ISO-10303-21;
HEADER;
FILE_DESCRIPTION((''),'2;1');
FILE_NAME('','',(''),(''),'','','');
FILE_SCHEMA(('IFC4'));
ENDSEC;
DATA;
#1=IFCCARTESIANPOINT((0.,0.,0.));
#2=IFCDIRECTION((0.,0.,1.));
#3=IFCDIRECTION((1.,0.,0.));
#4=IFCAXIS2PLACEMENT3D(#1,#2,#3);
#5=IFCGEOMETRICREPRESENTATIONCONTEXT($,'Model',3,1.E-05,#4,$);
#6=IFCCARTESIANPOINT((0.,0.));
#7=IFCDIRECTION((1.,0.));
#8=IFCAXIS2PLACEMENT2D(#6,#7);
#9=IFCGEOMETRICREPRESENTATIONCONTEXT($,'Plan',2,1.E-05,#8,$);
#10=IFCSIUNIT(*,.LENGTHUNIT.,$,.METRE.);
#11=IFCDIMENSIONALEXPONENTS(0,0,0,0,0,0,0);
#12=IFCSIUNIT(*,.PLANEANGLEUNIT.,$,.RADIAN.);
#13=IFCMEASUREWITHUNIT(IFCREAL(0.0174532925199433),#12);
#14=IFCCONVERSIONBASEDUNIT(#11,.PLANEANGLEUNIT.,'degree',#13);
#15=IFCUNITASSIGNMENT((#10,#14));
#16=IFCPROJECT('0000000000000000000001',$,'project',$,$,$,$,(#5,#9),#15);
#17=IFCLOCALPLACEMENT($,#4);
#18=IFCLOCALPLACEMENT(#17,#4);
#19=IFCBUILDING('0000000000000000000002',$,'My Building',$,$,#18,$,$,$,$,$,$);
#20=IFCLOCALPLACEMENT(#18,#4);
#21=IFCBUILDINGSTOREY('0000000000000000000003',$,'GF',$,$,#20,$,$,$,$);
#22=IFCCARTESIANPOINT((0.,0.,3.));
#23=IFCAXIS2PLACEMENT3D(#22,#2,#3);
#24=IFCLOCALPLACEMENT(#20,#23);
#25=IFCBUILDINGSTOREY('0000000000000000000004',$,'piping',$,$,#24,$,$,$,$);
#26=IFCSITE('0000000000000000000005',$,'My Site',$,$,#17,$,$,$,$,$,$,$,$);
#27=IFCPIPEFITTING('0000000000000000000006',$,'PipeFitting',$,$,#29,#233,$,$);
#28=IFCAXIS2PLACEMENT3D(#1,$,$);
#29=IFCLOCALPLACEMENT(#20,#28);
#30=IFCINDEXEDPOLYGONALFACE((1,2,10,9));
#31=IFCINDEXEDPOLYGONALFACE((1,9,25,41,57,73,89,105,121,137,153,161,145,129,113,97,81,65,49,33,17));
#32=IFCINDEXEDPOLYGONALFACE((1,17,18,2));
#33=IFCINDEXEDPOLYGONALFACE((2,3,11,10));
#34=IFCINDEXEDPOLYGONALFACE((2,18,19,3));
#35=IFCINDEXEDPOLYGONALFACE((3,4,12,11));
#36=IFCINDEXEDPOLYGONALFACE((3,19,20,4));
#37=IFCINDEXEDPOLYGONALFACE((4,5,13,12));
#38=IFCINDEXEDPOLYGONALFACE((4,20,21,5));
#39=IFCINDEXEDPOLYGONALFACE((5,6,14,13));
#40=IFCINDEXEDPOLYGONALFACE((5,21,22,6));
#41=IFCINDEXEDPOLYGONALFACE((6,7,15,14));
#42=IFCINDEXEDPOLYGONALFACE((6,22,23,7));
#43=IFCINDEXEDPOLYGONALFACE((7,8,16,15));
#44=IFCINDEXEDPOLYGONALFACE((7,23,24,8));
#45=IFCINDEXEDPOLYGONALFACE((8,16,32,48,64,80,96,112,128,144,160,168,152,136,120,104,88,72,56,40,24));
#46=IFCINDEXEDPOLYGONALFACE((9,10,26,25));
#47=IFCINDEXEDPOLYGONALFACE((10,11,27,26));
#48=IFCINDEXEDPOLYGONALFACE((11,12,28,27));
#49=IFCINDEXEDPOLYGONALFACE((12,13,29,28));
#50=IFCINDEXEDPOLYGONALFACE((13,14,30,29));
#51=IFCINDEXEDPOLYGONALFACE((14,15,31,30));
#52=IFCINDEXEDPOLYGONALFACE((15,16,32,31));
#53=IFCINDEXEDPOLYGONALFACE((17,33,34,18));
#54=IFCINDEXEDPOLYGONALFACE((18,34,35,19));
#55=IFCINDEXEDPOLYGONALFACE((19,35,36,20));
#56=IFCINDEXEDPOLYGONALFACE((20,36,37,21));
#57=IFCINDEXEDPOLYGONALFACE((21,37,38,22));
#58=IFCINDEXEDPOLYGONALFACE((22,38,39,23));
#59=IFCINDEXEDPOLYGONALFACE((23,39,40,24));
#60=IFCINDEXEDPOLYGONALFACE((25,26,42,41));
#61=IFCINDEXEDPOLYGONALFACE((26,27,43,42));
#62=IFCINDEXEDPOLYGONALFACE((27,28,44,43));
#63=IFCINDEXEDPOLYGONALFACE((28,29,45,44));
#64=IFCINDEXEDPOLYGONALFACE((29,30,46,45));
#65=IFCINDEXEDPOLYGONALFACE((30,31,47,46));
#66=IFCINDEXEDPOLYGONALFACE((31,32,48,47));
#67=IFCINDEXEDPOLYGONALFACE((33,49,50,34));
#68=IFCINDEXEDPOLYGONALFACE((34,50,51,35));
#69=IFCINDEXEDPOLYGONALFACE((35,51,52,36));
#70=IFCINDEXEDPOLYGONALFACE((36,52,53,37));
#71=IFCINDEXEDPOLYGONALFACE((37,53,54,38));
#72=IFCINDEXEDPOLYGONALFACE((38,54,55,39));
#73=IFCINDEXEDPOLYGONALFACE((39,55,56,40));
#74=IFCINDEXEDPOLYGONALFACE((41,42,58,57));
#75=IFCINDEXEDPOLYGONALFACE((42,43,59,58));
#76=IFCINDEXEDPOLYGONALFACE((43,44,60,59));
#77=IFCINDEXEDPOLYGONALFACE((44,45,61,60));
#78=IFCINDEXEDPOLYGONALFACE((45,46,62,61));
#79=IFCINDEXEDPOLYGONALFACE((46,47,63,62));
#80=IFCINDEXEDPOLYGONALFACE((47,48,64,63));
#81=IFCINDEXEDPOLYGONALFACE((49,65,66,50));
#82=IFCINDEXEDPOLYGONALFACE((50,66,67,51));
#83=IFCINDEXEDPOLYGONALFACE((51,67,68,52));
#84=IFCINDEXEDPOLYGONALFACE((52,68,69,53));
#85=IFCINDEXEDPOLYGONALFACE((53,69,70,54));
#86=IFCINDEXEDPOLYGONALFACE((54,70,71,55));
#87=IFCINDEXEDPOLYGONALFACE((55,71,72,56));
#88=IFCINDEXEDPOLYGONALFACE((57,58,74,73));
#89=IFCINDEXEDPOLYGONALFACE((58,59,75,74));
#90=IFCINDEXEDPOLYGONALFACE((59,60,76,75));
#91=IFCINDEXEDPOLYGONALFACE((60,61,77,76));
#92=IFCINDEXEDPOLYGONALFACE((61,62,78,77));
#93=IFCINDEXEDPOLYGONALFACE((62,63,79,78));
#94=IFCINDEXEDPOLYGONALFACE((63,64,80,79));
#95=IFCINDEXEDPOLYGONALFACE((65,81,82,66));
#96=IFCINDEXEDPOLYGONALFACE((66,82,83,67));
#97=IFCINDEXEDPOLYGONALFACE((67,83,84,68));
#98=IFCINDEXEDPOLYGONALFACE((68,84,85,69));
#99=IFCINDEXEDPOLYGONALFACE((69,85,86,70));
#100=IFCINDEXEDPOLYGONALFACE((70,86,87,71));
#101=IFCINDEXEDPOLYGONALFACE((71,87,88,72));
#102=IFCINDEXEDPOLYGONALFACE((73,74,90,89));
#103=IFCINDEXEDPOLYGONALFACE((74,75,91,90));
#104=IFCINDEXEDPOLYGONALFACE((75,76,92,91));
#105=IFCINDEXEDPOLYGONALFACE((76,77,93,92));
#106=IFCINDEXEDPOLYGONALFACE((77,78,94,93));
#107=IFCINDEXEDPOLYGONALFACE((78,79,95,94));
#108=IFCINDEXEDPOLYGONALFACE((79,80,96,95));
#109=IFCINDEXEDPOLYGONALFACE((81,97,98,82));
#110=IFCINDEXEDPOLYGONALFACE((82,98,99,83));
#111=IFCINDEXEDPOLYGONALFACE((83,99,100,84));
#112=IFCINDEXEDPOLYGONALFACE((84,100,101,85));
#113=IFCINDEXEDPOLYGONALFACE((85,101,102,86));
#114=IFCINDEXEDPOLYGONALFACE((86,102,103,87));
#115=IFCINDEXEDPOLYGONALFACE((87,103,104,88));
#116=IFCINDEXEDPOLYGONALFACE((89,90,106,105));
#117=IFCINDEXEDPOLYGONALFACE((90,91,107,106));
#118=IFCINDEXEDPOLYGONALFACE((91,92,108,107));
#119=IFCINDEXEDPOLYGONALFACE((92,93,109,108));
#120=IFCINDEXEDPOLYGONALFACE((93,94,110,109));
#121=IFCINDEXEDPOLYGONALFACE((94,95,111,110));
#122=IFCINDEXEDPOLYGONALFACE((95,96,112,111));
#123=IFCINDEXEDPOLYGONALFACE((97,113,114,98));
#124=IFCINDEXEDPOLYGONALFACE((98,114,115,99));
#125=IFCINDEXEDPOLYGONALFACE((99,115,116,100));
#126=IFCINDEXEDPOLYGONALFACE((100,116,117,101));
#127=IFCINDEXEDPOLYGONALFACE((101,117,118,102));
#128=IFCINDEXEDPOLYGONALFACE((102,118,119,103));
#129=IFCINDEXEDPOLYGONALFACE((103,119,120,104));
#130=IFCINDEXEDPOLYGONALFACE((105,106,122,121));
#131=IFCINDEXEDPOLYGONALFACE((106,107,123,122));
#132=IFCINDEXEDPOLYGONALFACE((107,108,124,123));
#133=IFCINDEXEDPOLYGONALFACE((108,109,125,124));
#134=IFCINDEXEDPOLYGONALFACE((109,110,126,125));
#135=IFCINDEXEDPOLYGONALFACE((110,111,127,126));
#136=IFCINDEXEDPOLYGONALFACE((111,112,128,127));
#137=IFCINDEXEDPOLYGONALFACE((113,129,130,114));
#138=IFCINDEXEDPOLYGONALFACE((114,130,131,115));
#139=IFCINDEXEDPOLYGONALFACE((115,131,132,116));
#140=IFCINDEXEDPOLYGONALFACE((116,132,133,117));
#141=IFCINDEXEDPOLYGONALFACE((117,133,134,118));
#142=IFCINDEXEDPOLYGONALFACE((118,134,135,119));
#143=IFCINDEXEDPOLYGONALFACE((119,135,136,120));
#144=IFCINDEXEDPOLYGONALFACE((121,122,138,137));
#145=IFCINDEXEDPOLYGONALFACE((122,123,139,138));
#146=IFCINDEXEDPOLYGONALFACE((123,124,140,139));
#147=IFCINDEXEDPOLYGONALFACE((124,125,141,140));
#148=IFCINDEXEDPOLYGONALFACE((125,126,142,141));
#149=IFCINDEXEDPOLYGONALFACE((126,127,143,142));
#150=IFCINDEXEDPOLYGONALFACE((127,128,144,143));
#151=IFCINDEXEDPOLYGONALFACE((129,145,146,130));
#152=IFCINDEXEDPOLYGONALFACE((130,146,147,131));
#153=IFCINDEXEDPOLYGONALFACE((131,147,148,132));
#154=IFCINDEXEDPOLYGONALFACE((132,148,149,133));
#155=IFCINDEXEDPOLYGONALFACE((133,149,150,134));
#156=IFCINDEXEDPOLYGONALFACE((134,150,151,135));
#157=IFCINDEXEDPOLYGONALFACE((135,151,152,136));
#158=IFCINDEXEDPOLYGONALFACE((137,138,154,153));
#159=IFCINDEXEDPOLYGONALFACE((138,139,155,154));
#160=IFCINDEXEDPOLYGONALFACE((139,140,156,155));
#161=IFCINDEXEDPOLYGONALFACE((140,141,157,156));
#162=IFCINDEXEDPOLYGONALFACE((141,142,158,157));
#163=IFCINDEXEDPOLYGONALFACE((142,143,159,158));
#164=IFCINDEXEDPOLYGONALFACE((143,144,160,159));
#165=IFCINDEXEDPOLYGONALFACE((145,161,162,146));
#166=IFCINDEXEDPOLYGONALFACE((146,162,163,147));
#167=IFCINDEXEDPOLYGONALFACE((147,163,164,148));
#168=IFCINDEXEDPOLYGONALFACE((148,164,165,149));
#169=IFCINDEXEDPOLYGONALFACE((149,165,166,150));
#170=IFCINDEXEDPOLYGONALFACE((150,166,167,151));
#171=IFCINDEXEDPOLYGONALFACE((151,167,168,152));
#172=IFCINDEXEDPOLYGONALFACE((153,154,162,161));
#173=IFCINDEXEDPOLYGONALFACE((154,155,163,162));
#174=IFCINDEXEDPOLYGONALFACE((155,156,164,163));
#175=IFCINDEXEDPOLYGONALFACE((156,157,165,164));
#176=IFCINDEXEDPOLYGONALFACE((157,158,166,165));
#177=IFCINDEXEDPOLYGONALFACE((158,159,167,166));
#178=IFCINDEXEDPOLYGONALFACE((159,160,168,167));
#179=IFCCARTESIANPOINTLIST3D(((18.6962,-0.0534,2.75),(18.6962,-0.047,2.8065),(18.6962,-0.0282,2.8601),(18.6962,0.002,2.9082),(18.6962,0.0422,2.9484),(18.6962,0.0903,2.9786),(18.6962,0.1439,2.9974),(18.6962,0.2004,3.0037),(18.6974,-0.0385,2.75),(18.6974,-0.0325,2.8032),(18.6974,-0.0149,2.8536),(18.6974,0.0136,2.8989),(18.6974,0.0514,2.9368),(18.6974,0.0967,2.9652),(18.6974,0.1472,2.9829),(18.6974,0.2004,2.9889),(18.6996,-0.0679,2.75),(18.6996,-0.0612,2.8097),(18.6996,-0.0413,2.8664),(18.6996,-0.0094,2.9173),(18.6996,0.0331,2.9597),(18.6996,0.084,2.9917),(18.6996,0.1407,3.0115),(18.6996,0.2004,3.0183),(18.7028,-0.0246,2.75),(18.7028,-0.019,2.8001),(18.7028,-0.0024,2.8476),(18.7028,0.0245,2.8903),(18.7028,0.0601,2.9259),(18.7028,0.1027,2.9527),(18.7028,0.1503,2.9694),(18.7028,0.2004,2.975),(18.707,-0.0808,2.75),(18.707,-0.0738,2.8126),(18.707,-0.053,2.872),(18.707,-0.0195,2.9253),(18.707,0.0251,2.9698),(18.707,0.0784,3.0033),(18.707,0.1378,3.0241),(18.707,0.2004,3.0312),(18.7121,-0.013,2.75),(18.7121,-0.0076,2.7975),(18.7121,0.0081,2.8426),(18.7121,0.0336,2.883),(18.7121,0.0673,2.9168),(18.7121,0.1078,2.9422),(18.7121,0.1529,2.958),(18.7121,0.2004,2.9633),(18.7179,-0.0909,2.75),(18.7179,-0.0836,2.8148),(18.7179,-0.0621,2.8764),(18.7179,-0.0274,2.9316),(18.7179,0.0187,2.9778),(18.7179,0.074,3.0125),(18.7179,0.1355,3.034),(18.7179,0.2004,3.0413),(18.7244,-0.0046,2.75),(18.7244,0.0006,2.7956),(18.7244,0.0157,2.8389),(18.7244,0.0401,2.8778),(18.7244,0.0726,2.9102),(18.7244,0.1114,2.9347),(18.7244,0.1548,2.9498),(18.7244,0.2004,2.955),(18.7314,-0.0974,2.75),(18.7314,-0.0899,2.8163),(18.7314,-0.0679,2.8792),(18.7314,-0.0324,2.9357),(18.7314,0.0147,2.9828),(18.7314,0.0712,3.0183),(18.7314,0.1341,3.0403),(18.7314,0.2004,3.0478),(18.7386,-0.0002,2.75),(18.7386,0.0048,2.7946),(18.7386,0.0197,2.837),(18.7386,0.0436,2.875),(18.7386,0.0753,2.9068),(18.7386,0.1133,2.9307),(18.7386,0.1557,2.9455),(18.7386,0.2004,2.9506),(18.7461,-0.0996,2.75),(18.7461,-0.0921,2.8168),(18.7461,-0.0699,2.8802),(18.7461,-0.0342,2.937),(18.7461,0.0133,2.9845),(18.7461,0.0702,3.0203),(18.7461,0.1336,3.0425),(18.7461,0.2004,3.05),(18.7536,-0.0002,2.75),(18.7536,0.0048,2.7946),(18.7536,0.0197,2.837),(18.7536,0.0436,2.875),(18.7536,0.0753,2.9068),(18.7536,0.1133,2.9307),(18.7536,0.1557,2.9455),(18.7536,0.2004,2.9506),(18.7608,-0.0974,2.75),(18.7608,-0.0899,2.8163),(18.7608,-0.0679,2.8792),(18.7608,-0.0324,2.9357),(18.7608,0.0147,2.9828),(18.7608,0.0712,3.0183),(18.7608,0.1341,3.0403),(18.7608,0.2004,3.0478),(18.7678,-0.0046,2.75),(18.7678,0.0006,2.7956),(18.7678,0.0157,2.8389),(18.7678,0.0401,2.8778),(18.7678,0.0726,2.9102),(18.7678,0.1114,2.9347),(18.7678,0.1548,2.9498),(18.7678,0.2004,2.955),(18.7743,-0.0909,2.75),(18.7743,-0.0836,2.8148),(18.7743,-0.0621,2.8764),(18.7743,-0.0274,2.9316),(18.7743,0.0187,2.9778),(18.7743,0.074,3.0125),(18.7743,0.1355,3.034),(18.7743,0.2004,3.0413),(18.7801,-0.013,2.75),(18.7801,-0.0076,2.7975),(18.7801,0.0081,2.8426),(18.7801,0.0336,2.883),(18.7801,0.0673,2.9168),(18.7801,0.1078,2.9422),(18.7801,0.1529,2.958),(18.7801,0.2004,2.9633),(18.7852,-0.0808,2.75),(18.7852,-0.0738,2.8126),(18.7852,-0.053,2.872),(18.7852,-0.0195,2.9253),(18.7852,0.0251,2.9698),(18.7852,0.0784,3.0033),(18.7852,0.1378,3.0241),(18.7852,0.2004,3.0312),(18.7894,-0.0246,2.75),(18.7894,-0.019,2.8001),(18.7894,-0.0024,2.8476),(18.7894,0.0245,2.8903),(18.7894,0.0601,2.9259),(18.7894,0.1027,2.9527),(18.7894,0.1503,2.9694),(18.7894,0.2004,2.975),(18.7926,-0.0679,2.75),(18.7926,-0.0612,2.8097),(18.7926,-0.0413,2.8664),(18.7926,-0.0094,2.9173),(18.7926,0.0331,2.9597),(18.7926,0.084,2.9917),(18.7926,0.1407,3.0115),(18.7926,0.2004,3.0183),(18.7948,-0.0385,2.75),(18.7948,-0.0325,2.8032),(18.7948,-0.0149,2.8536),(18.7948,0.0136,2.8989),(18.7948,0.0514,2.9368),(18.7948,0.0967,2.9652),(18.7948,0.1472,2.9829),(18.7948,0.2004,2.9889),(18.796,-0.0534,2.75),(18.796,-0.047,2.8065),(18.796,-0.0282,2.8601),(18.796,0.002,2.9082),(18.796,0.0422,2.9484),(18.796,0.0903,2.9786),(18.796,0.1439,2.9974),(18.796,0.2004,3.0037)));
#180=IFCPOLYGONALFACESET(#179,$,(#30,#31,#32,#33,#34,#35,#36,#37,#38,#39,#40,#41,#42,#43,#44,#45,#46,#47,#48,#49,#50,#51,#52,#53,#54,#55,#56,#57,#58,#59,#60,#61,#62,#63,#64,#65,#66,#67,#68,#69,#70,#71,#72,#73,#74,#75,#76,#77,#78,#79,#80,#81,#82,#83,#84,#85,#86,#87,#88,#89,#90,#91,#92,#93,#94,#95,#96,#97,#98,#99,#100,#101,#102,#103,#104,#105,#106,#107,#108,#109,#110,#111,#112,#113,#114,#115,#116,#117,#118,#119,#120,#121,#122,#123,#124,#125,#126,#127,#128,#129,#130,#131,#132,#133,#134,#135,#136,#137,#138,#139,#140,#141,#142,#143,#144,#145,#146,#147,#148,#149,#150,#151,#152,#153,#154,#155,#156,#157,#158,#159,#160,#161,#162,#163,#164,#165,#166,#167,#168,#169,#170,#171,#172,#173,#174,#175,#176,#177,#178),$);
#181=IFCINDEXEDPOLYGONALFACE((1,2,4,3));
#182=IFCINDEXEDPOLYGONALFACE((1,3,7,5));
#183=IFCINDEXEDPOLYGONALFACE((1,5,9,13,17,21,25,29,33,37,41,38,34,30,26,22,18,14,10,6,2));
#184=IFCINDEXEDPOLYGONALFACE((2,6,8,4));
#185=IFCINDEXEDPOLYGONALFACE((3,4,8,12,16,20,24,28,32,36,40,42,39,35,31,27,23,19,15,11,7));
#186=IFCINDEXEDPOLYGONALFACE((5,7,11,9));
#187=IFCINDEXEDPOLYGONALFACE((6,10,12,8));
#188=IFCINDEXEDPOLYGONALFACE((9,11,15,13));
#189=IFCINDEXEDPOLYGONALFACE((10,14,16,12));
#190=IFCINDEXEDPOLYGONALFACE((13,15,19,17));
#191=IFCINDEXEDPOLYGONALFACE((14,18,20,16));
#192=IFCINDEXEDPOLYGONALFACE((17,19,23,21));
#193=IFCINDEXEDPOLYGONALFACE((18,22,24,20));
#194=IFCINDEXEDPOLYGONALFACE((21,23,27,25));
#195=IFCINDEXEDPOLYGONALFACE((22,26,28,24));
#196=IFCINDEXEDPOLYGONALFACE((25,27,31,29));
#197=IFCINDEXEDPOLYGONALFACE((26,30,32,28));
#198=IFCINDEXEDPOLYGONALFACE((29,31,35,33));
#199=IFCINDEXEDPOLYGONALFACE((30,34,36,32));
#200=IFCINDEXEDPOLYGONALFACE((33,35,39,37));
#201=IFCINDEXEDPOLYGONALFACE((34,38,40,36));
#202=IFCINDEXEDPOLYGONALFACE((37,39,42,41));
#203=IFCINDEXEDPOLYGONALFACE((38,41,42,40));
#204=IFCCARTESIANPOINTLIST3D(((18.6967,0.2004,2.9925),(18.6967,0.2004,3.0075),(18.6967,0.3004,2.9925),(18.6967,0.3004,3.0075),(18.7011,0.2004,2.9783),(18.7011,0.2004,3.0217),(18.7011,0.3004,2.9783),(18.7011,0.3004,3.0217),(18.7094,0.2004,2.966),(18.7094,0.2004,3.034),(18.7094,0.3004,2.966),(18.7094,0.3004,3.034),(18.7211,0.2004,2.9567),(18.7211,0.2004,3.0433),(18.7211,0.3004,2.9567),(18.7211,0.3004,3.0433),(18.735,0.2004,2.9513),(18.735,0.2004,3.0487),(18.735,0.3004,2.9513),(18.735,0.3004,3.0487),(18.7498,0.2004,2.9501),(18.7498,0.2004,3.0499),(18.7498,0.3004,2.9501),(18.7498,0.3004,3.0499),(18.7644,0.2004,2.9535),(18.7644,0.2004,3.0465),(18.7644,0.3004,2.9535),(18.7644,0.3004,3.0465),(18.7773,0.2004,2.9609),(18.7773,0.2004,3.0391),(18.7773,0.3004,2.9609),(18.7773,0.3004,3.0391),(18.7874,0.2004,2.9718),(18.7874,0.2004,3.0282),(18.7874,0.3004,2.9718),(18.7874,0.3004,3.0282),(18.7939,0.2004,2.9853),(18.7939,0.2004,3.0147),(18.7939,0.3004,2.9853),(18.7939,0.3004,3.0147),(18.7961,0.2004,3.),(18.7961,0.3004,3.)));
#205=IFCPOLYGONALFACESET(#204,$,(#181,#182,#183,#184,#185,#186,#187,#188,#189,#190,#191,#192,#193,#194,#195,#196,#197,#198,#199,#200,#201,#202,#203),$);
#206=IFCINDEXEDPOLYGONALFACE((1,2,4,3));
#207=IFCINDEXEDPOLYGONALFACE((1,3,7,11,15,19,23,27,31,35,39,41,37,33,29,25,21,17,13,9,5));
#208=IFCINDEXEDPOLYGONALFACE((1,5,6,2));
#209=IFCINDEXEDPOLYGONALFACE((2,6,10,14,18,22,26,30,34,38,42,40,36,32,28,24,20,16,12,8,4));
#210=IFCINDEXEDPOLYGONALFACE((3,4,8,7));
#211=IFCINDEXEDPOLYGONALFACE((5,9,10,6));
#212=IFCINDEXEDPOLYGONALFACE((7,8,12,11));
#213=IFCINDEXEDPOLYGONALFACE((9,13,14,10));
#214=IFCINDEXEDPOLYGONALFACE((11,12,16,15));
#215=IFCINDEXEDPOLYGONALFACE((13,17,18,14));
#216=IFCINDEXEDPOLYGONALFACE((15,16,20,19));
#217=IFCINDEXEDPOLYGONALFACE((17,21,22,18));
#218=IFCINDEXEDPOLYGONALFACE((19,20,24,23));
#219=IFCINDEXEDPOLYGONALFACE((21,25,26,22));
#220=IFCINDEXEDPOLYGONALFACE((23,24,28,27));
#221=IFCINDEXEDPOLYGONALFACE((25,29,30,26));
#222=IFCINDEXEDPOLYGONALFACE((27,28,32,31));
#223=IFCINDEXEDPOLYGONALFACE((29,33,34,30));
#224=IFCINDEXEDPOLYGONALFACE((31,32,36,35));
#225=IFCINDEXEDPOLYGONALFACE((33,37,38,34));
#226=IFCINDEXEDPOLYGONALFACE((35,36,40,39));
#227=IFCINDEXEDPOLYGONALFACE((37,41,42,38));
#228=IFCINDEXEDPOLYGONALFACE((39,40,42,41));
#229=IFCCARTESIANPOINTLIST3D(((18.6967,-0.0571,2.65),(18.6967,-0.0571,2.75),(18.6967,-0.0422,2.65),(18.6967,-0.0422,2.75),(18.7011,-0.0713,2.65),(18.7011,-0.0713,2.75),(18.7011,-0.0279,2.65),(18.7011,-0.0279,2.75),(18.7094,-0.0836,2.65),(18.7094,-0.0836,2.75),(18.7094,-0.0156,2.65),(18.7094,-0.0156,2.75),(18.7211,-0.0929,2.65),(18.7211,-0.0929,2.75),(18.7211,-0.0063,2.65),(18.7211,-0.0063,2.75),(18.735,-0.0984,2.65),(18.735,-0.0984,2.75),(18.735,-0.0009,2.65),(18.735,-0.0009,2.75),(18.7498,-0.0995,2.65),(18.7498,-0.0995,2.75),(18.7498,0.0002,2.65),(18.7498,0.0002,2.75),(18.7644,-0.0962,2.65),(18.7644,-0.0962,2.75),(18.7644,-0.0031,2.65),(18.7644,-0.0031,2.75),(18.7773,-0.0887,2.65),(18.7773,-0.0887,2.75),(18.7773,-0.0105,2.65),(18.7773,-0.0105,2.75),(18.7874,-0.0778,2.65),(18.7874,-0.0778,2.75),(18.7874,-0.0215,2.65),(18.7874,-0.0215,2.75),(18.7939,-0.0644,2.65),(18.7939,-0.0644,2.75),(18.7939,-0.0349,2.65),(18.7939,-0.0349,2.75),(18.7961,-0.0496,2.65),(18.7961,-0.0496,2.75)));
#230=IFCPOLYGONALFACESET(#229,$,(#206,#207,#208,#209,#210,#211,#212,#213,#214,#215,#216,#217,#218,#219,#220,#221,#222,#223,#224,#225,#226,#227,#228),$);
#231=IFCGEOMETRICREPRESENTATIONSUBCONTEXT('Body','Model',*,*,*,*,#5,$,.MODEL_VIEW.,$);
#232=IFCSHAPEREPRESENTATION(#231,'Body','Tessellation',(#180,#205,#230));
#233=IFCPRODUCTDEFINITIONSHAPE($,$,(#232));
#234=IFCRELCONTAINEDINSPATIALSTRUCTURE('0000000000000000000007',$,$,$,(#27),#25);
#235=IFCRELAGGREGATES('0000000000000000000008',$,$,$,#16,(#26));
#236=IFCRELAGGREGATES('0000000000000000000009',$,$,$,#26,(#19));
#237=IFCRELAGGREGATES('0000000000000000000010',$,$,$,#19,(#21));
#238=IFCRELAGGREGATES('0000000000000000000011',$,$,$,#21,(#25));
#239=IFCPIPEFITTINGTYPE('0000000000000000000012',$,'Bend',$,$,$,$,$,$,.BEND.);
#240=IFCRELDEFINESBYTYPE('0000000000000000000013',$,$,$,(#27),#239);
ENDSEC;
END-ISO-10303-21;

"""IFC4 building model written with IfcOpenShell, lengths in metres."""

from ifc_helpers import new_model, entity, si_unit, converted_unit, frame, origin_with_axes, origin_2d_with_axis, place, context, subcontext, project, spatial, circle, extrude, source, transform, mapped, type_object, type_shapes, element, save


model = new_model("IFC4")

# Units and contexts
model_context = context("Model", 3, precision=1e-05, world=origin_with_axes())
plan_context = context("Plan", 2, precision=1e-05, world=origin_2d_with_axis())
body_context = subcontext(model_context, "Body", "Model", "MODEL_VIEW")
ifc_project = project(units=[si_unit("LENGTHUNIT", "METRE"), converted_unit("PLANEANGLEUNIT", "degree", entity("IfcReal", 0.0174532925199433), si_unit("PLANEANGLEUNIT", "RADIAN"), dimensions=[0, 0, 0, 0, 0, 0, 0])], contexts=[model_context, plan_context])

# Site, building, storeys
site_placement = place(None, origin_with_axes())
site = spatial("IfcSite", under=ifc_project, at=site_placement, Name="My Site")
building_placement = place(site_placement, origin_with_axes())
building = spatial("IfcBuilding", under=site, at=building_placement, Name="My Building")
storey_1_placement = place(building_placement, origin_with_axes())
storey_1 = spatial("IfcBuildingStorey", under=building, at=storey_1_placement, Name="GF")
storey_2_placement = place(storey_1_placement, frame((0.0, 0.0, 3.0), z_axis=(0.0, 0.0, 1.0), x_axis=(1.0, 0.0, 0.0)))
storey_2 = spatial("IfcBuildingStorey", under=storey_1, at=storey_2_placement, Name="piping")

# Pipe fitting
pipe_fitting_type = type_object("IfcPipeFittingType", Name="Bend", PredefinedType="BEND")
shared_shape = source(origin_with_axes(), body_context, "Body", "SolidModel", [
    entity("IfcSweptDiskSolid", entity("IfcIndexedPolyCurve", entity("IfcCartesianPointList3D", [[0.0, 0.0, -0.1], [0.0, 0.0732, -0.2768], [0.0, 0.25, -0.35]]), [entity("IfcArcIndex", [1, 2, 3])]), 0.05),
    extrude(circle(Radius=0.05), origin_with_axes(), (0.0, 0.0, -1.0), 0.1),
    extrude(circle(Radius=0.05), frame((0.0, 0.25, -0.35), z_axis=(0.0, 1.0, 0.0), x_axis=(1.0, 0.0, 0.0)), (0.0, 0.0, 1.0), 0.1),
])
type_shapes(pipe_fitting_type, [shared_shape])
for number, where, z_axis, x_axis, name in (
    (1, (18.7461, 0.3004, 0.0), (0.0, 1.0, 0.0), (1.0, 0.0, 0.0), "PipeFitting"),
):
    element("IfcPipeFitting", number, at=place(storey_2_placement, frame(where, z_axis=z_axis, x_axis=x_axis)), inside=storey_2, type_object=pipe_fitting_type, Name=name, context=body_context, shape_type="MappedRepresentation", body=[
        mapped(shared_shape, transform((0.0, 0.0, 0.0), x_axis=(1.0, 0.0, 0.0), y_axis=(0.0, 1.0, 0.0), z_axis=(0.0, 0.0, 1.0), scale=1.0)),
    ])

save(model, "model.ifc")
